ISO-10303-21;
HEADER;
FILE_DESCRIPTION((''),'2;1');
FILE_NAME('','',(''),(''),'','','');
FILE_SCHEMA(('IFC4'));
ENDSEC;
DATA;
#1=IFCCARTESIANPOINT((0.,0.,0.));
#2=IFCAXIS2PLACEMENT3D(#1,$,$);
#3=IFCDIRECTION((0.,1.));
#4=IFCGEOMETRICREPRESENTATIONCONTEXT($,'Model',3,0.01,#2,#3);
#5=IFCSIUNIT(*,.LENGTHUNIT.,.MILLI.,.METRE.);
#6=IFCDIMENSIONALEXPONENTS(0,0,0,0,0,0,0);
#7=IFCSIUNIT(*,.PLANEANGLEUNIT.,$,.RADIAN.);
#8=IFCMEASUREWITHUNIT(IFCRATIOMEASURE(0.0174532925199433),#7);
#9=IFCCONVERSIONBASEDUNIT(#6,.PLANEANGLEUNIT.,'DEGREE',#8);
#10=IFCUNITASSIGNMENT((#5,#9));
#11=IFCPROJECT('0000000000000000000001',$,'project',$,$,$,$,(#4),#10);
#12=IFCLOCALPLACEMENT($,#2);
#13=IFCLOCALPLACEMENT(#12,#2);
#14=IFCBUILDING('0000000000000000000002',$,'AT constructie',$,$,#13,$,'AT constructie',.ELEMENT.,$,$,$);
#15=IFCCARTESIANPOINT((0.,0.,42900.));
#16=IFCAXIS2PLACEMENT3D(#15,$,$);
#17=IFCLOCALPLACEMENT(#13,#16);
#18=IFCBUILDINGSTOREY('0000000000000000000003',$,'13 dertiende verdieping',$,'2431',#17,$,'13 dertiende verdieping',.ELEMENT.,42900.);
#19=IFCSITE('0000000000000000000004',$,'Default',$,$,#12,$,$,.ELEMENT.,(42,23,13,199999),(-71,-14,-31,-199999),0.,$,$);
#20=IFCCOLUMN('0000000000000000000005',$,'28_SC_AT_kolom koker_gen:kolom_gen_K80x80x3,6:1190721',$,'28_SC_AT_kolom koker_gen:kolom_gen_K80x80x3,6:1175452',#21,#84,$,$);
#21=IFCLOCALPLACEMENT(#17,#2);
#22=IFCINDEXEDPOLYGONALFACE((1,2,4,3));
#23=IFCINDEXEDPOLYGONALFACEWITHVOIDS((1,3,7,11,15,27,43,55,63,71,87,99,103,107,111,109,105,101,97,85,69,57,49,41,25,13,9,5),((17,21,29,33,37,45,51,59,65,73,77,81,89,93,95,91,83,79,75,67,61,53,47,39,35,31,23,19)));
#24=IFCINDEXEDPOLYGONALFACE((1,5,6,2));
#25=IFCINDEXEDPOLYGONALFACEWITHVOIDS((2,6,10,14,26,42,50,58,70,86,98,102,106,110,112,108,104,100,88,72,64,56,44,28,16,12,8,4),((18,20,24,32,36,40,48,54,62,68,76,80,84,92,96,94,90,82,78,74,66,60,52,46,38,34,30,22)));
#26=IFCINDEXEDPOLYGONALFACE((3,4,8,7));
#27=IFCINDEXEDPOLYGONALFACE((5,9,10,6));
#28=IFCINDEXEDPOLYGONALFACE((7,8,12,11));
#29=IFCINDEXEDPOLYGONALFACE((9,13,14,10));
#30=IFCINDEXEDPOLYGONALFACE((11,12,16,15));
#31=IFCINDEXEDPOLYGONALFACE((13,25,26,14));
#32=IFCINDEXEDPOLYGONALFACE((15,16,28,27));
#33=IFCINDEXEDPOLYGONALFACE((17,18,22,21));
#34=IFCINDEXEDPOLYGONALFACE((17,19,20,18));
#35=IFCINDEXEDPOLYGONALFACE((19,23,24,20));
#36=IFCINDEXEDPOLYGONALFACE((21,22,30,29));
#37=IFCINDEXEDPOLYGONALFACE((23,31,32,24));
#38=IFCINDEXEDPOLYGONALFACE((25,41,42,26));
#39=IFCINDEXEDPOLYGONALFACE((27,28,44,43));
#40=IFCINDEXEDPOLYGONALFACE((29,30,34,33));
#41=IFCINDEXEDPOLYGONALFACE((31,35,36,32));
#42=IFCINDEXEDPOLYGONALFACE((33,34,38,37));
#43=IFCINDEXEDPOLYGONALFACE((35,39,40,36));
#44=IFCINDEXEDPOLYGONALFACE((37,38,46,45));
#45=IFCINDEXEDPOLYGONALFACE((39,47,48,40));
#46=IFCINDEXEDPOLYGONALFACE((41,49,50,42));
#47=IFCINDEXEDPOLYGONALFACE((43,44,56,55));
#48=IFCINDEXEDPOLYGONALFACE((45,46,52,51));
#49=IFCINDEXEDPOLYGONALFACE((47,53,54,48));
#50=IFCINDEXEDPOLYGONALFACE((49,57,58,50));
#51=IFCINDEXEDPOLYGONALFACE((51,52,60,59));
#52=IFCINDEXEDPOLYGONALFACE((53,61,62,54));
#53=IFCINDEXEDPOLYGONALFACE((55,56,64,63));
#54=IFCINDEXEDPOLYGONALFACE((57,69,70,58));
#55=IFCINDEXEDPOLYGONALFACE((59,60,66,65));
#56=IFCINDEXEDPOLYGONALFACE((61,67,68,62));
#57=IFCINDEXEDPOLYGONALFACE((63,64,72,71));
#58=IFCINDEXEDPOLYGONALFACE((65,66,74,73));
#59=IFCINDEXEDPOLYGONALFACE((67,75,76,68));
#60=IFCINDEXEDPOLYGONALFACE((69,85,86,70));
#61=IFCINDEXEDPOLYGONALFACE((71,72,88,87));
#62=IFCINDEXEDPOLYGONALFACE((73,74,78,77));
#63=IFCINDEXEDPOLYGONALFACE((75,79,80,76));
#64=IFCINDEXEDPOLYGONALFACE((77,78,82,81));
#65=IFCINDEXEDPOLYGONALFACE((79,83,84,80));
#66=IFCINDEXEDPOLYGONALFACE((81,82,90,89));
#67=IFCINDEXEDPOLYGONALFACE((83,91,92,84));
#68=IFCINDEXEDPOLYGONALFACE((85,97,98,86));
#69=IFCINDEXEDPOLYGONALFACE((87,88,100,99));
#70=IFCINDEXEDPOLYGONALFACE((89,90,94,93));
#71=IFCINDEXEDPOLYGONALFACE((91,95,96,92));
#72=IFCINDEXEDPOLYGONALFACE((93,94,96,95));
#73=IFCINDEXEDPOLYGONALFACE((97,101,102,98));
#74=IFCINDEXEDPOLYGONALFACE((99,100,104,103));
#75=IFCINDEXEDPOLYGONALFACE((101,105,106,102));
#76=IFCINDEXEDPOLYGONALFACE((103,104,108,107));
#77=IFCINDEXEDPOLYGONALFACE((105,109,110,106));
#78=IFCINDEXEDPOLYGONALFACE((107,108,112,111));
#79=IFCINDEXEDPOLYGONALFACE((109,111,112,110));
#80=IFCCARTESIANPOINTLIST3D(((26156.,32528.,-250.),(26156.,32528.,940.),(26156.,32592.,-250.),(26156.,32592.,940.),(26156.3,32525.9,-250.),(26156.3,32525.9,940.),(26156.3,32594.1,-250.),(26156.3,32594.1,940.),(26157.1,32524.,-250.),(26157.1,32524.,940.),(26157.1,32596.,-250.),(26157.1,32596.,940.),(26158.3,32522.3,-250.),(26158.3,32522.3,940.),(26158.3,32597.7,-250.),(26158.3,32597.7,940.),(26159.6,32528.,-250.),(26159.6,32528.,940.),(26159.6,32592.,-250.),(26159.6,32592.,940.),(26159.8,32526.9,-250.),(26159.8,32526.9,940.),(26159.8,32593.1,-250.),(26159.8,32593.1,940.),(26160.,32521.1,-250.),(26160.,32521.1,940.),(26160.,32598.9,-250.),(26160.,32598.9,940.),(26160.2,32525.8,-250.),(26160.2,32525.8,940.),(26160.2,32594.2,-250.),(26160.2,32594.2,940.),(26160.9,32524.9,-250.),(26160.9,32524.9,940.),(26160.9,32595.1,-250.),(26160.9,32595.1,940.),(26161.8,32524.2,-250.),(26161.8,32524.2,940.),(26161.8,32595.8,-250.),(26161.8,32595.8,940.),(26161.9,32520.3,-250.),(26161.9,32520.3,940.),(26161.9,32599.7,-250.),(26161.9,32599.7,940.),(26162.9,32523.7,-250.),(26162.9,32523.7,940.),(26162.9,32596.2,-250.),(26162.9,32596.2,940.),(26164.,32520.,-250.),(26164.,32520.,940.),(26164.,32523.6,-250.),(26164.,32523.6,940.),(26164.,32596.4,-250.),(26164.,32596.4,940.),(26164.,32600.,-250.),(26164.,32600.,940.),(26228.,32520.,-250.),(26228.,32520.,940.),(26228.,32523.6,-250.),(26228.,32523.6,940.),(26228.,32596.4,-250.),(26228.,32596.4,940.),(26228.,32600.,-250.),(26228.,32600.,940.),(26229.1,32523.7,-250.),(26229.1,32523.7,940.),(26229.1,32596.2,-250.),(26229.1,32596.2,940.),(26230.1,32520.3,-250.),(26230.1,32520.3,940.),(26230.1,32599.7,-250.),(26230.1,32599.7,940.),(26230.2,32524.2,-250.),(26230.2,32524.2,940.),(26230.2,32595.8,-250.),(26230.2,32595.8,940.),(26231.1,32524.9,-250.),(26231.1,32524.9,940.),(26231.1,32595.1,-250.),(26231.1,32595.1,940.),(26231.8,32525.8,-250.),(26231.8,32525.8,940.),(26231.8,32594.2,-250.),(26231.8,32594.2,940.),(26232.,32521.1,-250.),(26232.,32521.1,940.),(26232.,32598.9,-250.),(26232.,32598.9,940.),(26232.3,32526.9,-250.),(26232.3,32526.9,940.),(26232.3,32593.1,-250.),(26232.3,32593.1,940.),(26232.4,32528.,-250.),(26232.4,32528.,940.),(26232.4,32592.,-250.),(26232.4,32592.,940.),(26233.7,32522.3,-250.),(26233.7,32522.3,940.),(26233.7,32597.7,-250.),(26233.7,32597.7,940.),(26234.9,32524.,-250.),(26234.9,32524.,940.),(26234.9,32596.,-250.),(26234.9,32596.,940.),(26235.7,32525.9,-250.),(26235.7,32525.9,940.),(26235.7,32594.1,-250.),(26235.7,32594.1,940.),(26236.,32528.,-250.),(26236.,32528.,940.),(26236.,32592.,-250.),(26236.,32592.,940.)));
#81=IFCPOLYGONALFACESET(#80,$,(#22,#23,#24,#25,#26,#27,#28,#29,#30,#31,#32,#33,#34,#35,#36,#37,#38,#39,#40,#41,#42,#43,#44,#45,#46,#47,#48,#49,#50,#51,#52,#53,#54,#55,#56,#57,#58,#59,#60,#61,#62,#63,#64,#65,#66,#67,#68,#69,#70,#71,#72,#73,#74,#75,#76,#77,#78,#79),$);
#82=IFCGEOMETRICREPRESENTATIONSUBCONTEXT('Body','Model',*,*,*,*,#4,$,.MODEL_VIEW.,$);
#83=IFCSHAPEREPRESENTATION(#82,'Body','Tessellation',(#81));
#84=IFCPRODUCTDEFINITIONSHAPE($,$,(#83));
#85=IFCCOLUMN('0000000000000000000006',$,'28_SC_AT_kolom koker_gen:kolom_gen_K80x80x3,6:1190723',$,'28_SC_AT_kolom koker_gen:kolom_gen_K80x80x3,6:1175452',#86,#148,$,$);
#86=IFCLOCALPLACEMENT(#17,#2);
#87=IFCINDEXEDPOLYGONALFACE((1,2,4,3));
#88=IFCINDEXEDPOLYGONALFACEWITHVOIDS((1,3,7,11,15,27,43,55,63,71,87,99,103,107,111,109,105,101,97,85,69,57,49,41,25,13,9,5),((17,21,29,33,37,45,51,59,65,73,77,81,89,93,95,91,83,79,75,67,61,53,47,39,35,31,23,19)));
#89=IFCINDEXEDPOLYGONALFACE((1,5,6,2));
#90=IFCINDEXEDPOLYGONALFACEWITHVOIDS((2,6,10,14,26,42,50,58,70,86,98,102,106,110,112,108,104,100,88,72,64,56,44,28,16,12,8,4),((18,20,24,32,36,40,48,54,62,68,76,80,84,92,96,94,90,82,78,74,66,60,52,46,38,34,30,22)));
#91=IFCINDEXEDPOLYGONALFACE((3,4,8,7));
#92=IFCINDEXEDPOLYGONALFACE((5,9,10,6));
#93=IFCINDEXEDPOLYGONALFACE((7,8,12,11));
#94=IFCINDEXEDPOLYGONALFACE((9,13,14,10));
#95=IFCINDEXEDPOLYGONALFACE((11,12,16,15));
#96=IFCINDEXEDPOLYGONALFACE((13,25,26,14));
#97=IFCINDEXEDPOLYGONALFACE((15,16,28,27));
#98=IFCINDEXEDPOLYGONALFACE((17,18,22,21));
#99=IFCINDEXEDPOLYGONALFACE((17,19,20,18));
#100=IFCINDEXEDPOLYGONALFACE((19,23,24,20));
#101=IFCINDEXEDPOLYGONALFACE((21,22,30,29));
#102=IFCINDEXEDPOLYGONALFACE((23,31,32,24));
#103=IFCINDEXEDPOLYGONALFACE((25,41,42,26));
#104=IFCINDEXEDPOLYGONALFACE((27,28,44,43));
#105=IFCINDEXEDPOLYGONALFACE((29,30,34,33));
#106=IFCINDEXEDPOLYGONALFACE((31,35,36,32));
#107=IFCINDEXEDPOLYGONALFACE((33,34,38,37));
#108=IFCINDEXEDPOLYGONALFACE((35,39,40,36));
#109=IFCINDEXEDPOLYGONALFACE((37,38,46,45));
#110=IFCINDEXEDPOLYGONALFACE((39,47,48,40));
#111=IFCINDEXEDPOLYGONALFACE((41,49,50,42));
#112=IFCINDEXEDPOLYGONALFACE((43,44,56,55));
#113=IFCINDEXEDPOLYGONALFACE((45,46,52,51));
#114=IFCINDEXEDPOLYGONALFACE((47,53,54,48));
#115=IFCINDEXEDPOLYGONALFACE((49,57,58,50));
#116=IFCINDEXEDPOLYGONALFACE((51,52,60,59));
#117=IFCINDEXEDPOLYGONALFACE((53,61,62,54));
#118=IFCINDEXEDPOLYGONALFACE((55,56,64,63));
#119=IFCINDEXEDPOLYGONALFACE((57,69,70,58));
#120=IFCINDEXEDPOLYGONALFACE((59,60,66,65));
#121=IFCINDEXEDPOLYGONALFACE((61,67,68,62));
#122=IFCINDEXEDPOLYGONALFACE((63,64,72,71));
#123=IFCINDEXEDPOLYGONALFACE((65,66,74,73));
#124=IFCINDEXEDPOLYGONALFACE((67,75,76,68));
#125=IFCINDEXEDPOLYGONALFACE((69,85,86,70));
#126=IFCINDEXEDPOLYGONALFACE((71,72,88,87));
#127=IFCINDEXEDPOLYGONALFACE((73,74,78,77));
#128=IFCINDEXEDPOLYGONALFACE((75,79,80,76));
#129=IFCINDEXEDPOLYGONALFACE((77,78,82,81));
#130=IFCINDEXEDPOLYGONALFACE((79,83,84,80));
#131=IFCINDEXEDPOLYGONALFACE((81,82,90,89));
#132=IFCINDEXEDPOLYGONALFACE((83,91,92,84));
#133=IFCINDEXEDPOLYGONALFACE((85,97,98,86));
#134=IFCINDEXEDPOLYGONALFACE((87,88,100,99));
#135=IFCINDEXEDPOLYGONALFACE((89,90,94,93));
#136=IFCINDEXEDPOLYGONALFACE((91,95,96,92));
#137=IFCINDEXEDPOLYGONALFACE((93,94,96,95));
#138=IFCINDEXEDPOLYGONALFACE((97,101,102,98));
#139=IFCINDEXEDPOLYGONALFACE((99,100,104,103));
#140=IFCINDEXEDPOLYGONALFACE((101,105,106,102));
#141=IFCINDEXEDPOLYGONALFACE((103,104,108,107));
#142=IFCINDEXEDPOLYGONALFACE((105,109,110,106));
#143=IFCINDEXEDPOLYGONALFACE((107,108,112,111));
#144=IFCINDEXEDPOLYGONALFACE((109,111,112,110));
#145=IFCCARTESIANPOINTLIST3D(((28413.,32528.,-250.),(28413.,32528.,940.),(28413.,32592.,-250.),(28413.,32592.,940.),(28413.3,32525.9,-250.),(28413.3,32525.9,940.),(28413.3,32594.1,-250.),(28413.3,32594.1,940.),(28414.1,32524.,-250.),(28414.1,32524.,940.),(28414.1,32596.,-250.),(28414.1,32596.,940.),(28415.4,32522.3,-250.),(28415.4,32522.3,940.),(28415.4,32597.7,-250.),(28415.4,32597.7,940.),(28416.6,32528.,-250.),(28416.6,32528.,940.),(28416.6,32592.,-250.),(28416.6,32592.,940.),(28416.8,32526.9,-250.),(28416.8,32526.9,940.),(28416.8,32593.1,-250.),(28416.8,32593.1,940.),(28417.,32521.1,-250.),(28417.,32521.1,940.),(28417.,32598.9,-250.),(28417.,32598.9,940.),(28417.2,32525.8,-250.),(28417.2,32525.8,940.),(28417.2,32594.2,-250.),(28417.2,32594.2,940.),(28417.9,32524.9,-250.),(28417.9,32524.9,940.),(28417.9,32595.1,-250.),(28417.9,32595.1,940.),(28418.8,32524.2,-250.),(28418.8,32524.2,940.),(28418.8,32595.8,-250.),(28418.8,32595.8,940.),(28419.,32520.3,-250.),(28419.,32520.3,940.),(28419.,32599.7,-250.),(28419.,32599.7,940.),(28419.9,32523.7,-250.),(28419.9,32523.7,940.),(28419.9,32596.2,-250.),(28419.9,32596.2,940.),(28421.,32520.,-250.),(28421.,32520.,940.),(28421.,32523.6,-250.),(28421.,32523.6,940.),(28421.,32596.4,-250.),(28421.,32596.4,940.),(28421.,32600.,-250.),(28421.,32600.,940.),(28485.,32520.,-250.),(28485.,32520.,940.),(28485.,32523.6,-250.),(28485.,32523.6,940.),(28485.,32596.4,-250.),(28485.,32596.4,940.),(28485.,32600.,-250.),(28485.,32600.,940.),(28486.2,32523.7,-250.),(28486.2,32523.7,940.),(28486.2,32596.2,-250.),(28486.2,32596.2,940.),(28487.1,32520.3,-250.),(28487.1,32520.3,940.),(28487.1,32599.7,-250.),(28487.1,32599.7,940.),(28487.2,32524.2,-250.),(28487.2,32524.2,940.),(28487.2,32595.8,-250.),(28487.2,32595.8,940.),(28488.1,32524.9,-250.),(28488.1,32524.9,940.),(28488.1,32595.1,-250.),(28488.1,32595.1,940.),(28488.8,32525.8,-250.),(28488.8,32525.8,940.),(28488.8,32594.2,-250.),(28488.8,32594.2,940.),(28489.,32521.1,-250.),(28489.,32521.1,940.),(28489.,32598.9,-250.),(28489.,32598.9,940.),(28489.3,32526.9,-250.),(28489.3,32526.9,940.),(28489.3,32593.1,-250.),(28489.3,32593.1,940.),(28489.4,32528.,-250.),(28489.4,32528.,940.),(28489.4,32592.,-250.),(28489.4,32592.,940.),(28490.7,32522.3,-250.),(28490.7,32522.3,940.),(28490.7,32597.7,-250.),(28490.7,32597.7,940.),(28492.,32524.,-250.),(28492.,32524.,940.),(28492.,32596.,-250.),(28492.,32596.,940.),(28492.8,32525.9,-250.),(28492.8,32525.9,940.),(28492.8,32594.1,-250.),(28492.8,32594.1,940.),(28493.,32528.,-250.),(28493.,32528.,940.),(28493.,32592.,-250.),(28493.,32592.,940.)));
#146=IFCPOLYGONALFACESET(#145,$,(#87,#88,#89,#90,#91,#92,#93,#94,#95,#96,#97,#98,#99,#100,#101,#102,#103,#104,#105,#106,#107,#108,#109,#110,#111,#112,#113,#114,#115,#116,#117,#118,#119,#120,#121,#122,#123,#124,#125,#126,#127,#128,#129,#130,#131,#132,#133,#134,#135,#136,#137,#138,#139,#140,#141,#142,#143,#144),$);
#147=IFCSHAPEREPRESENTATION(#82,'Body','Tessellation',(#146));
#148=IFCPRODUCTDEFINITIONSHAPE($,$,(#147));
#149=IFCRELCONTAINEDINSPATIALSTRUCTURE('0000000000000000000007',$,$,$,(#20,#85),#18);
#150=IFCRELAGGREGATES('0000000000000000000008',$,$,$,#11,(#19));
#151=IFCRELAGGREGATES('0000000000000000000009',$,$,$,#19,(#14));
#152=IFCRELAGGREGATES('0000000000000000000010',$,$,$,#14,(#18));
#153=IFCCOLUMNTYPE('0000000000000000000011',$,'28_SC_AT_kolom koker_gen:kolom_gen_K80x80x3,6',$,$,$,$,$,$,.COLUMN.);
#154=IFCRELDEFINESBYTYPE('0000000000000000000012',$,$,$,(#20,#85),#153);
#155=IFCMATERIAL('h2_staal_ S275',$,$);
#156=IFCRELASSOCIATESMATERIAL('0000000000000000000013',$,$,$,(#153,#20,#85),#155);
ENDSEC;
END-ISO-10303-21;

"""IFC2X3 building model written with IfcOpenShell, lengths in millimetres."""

from ifc_helpers import new_model, entity, si_unit, converted_unit, direction, frame, frame_2d, origin, place, context, subcontext, project, spatial, polyline, circle_curve, parameter, trimmed, segment, composite_curve, outline, extrude, source, transform, mapped, material, type_object, type_shapes, element, save


model = new_model("IFC2X3")

# Units and contexts
model_context = context("Model", 3, precision=0.01, world=origin(), true_north=direction((0.0, 1.0)))
body_context = subcontext(model_context, "Body", "Model", "MODEL_VIEW")
ifc_project = project(units=[si_unit("LENGTHUNIT", "METRE", prefix="MILLI"), converted_unit("PLANEANGLEUNIT", "DEGREE", entity("IfcRatioMeasure", 0.0174532925199433), si_unit("PLANEANGLEUNIT", "RADIAN"), dimensions=[0, 0, 0, 0, 0, 0, 0])], contexts=[model_context])

# Site, building, storey
site_placement = place(None, origin())
site = spatial("IfcSite", under=ifc_project, at=site_placement, Name="Default", CompositionType="ELEMENT", RefLatitude=(42, 23, 13, 199999), RefLongitude=(-71, -14, -31, -199999), RefElevation=0.0)
building_placement = place(site_placement, origin())
building = spatial("IfcBuilding", under=site, at=building_placement, Name="AT constructie", LongName="AT constructie", CompositionType="ELEMENT")
storey_placement = place(building_placement, frame((0.0, 0.0, 42900.0)))
storey = spatial("IfcBuildingStorey", under=building, at=storey_placement, Name="13 dertiende verdieping", ObjectType="2431", LongName="13 dertiende verdieping", CompositionType="ELEMENT", Elevation=42900.0)

# Columns
ifc_material = material(Name="h2_staal_ S275")
column_type_1 = type_object("IfcColumnType", Name="28_SC_AT_kolom koker_gen:kolom_gen_K80x80x3,6", PredefinedType="COLUMN", material=ifc_material)
shared_shape_1 = source(origin(), body_context, "Body", "SweptSolid", [
    extrude(outline(composite_curve([segment(trimmed(circle_curve(frame_2d((32.0, 32.0), x_axis=(1.0, 0.0)), 8.0), [parameter(360.0)], [parameter(90.0)], True, "PARAMETER"), True, "CONTINUOUS"), segment(polyline([(32.0, 40.0), (-32.0, 40.0)]), True, "CONTINUOUS"), segment(trimmed(circle_curve(frame_2d((-32.0, 32.0), x_axis=(1.0, 0.0)), 8.0), [parameter(90.0)], [parameter(180.0)], True, "PARAMETER"), True, "CONTINUOUS"), segment(polyline([(-40.0, 32.0), (-40.0, -32.0)]), True, "CONTINUOUS"), segment(trimmed(circle_curve(frame_2d((-32.0, -32.0), x_axis=(1.0, 0.0)), 8.0), [parameter(180.0)], [parameter(270.0)], True, "PARAMETER"), True, "CONTINUOUS"), segment(polyline([(-32.0, -40.0), (32.0, -40.0)]), True, "CONTINUOUS"), segment(trimmed(circle_curve(frame_2d((32.0, -32.0), x_axis=(1.0, 0.0)), 8.0), [parameter(270.0)], [parameter(0.0)], True, "PARAMETER"), True, "CONTINUOUS"), segment(polyline([(40.0, -32.0), (40.0, 32.0)]), True, "CONTINUOUS")], self_intersect=False), holes=[composite_curve([segment(polyline([(-32.0, 36.4), (32.0, 36.4)]), True, "CONTINUOUS"), segment(trimmed(circle_curve(frame_2d((32.0, 32.0), x_axis=(1.0, 0.0)), 4.4), [parameter(360.0)], [parameter(90.0)], True, "PARAMETER"), False, "CONTINUOUS"), segment(polyline([(36.4, 32.0), (36.4, -32.0)]), True, "CONTINUOUS"), segment(trimmed(circle_curve(frame_2d((32.0, -32.0), x_axis=(1.0, 0.0)), 4.4), [parameter(270.0)], [parameter(360.0)], True, "PARAMETER"), False, "CONTINUOUS"), segment(polyline([(32.0, -36.4), (-32.0, -36.4)]), True, "CONTINUOUS"), segment(trimmed(circle_curve(frame_2d((-32.0, -32.0), x_axis=(1.0, 0.0)), 4.4), [parameter(180.0)], [parameter(270.0)], True, "PARAMETER"), False, "CONTINUOUS"), segment(polyline([(-36.4, -32.0), (-36.4, 32.0)]), True, "CONTINUOUS"), segment(trimmed(circle_curve(frame_2d((-32.0, 32.0), x_axis=(1.0, 0.0)), 4.4), [parameter(90.0)], [parameter(180.0)], True, "PARAMETER"), False, "CONTINUOUS")], self_intersect=False)]), frame((0.0, 0.0, 42650.0), z_axis=(0.0, 0.0, 1.0), x_axis=(-1.0, 0.0, 0.0)), (0.0, 0.0, 1.0), 1190.0),
])
type_shapes(column_type_1, [shared_shape_1])
for number, where, name in (
    (1, (26196.0, 32560.0, -42900.0), "28_SC_AT_kolom koker_gen:kolom_gen_K80x80x3,6:1190721"),
    (2, (28453.0, 32560.0, -42900.0), "28_SC_AT_kolom koker_gen:kolom_gen_K80x80x3,6:1190723"),
):
    element("IfcColumn", number, at=place(storey_placement, frame(where)), inside=storey, type_object=column_type_1, material=ifc_material, Name=name, ObjectType="28_SC_AT_kolom koker_gen:kolom_gen_K80x80x3,6:1175452", context=body_context, shape_type="MappedRepresentation", body=[
        mapped(shared_shape_1, transform((0.0, 0.0, 0.0), scale=1.0)),
    ])

save(model, "model.ifc")
